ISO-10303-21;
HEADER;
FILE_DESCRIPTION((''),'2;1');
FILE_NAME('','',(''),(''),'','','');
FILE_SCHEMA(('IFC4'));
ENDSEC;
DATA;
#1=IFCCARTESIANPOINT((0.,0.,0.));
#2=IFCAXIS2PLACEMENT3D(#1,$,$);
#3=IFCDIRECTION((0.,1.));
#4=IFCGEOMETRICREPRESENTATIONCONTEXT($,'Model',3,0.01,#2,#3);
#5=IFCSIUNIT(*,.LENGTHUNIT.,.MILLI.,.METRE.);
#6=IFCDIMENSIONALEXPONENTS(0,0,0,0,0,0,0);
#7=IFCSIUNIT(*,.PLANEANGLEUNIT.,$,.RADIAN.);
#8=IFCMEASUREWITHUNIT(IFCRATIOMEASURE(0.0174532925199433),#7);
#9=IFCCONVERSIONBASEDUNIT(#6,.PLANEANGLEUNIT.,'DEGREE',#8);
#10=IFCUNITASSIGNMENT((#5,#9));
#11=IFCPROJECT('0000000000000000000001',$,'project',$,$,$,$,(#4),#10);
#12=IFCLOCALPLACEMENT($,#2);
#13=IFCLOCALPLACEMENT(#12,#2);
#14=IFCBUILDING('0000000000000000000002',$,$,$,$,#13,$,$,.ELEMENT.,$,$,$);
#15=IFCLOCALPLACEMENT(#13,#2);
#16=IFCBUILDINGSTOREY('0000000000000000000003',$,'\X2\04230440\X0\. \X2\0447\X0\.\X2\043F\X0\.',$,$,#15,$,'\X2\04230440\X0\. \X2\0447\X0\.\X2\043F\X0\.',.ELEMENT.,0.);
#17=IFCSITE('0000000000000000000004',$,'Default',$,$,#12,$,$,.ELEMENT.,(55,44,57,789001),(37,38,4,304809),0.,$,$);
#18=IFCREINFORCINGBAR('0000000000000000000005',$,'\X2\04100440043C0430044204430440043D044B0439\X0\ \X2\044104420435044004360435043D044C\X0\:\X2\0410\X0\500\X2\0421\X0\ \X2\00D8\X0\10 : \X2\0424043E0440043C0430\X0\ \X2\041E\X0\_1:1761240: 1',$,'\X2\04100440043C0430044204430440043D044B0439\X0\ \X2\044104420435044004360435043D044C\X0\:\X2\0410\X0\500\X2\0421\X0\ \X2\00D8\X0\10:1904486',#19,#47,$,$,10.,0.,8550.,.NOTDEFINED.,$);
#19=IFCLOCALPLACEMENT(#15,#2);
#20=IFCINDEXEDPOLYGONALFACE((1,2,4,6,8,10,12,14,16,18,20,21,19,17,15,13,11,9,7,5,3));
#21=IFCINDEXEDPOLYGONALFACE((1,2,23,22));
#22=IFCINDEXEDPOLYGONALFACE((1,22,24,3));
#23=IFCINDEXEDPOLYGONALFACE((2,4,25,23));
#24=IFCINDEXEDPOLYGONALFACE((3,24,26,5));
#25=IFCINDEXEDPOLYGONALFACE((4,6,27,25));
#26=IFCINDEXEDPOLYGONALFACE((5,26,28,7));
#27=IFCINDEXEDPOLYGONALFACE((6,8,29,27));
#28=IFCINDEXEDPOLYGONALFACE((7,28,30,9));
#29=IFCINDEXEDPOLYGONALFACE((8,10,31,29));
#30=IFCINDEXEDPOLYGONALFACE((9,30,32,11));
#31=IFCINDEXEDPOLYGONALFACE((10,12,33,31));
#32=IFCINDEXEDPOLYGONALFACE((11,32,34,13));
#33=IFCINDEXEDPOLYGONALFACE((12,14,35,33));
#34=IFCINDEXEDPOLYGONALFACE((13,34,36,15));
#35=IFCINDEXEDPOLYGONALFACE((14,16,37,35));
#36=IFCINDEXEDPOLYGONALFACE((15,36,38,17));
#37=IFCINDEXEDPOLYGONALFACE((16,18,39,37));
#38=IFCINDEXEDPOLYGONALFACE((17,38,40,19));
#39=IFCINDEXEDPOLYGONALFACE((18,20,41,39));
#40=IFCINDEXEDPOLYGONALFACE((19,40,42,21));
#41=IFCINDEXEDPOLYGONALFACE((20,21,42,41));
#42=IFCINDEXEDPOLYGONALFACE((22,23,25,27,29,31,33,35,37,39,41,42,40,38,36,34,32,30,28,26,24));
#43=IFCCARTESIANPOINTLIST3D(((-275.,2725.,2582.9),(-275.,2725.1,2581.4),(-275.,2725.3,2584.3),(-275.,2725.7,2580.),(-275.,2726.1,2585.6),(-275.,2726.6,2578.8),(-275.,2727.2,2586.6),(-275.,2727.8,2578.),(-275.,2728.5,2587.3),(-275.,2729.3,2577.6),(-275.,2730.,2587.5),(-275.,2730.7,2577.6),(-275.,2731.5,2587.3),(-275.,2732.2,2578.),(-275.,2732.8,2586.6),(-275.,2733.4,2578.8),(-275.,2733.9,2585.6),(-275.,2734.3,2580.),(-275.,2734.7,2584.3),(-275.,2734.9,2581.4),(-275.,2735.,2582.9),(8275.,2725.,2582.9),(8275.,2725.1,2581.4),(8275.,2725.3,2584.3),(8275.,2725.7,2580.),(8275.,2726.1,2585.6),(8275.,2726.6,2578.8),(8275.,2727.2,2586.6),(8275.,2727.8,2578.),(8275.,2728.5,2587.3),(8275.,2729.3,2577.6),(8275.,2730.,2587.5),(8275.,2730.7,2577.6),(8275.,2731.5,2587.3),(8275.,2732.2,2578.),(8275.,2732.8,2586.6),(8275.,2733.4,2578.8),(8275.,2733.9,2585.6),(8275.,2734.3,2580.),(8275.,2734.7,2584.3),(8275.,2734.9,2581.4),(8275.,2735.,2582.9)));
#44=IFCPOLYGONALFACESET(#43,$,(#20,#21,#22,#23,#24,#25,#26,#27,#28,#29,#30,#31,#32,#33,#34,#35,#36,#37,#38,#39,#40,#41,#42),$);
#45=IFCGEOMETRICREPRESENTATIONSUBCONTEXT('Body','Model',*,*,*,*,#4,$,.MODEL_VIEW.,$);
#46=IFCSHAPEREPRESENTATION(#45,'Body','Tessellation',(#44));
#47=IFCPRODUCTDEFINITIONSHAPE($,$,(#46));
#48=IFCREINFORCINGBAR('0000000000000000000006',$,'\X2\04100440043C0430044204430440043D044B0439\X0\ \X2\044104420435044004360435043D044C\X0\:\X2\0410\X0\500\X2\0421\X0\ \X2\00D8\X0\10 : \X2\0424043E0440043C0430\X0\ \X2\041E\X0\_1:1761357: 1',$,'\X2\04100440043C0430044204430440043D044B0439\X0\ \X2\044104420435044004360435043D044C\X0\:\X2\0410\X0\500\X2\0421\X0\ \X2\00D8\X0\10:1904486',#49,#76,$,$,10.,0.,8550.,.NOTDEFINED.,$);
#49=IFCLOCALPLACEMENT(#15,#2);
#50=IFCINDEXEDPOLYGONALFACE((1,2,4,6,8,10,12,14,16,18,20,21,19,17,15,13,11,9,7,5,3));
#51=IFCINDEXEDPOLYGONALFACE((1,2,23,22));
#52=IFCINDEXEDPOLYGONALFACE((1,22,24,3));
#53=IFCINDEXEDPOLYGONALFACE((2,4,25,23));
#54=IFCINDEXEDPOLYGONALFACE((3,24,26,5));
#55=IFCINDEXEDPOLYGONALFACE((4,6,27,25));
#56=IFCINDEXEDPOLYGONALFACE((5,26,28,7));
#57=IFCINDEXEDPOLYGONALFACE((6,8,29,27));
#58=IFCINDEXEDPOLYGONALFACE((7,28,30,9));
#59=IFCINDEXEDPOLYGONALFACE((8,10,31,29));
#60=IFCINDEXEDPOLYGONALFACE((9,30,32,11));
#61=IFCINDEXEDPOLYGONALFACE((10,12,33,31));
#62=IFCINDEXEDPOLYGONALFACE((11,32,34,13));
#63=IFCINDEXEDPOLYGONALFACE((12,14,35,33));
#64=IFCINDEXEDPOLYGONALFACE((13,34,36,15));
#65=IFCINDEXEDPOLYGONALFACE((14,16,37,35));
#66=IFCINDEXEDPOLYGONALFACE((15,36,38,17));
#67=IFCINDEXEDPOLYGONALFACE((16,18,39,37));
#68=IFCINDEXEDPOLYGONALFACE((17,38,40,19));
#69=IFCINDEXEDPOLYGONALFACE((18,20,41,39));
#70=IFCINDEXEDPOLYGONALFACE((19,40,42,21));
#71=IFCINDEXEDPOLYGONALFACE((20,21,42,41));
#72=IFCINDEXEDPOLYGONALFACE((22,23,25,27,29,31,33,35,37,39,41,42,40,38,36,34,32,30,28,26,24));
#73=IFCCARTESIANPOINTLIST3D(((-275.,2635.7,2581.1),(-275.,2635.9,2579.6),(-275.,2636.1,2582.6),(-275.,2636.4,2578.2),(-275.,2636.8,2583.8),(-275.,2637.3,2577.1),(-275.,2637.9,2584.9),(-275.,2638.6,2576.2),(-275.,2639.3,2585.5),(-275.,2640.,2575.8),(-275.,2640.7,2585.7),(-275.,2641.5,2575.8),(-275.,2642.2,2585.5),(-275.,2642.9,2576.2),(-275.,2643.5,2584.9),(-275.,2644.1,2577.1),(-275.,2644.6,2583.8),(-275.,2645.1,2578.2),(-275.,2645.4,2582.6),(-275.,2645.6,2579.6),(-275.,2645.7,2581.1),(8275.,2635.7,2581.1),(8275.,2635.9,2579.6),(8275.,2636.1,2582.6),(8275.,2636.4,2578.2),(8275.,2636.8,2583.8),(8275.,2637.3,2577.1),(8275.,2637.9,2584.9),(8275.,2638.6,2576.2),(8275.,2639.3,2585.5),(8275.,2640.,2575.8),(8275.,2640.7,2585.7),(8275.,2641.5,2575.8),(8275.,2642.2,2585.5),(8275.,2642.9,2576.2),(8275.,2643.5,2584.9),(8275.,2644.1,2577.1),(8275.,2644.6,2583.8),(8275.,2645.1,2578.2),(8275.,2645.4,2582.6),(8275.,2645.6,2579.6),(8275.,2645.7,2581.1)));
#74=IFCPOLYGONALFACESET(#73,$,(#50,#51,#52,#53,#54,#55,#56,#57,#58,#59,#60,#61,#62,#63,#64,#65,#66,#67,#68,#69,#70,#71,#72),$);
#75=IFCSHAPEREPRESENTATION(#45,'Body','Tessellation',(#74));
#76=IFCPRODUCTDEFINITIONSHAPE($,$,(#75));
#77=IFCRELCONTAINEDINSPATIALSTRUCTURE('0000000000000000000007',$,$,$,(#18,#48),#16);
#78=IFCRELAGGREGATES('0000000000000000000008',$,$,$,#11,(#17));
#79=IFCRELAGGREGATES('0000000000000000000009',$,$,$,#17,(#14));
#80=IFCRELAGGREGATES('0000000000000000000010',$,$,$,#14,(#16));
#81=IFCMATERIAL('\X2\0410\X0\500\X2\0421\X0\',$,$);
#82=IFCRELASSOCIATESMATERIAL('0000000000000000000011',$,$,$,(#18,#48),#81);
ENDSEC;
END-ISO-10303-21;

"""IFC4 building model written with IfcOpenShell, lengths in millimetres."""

from ifc_helpers import new_model, entity, si_unit, converted_unit, direction, origin, place, context, subcontext, project, spatial, material, element, save


model = new_model("IFC4")

# Units and contexts
model_context = context("Model", 3, precision=0.01, world=origin(), true_north=direction((0.0, 1.0)))
body_context = subcontext(model_context, "Body", "Model", "MODEL_VIEW")
ifc_project = project(units=[si_unit("LENGTHUNIT", "METRE", prefix="MILLI"), converted_unit("PLANEANGLEUNIT", "DEGREE", entity("IfcRatioMeasure", 0.0174532925199433), si_unit("PLANEANGLEUNIT", "RADIAN"), dimensions=[0, 0, 0, 0, 0, 0, 0])], contexts=[model_context])

# Site, building, storey
site_placement = place(None, origin())
site = spatial("IfcSite", under=ifc_project, at=site_placement, Name="Default", CompositionType="ELEMENT", RefLatitude=(55, 44, 57, 789001), RefLongitude=(37, 38, 4, 304809), RefElevation=0.0)
building_placement = place(site_placement, origin())
building = spatial("IfcBuilding", under=site, at=building_placement, CompositionType="ELEMENT")
storey_placement = place(building_placement, origin())
storey = spatial("IfcBuildingStorey", under=building, at=storey_placement, Name="Ур. ч.п.", LongName="Ур. ч.п.", CompositionType="ELEMENT", Elevation=0.0)

# Reinforcing bars
ifc_material_1 = material(Name="А500С")
reinforcing_bar_1_placement = place(storey_placement, origin())
element("IfcReinforcingBar", 1, at=reinforcing_bar_1_placement, inside=storey, material=ifc_material_1, Name="Арматурный стержень:А500С Ø10 : Форма О_1:1761240: 1", ObjectType="Арматурный стержень:А500С Ø10:1904486", BarLength=8550.0, CrossSectionArea=0.0, NominalDiameter=10.0, PredefinedType="NOTDEFINED", context=body_context, shape_type="AdvancedSweptSolid", body=[
    entity("IfcSweptDiskSolid", entity("IfcCompositeCurve", [entity("IfcCompositeCurveSegment", "CONTINUOUS", True, entity("IfcPolyline", [entity("IfcCartesianPoint", [-275.0, 2730.0, 2582.5]), entity("IfcCartesianPoint", [8275.0, 2730.0, 2582.5])]))], False), 5.0, None, 0.0, 1.0),
])
reinforcing_bar_2_placement = place(storey_placement, origin())
element("IfcReinforcingBar", 2, at=reinforcing_bar_2_placement, inside=storey, material=ifc_material_1, Name="Арматурный стержень:А500С Ø10 : Форма О_1:1761357: 1", ObjectType="Арматурный стержень:А500С Ø10:1904486", BarLength=8550.0, CrossSectionArea=0.0, NominalDiameter=10.0, PredefinedType="NOTDEFINED", context=body_context, shape_type="AdvancedSweptSolid", body=[
    entity("IfcSweptDiskSolid", entity("IfcCompositeCurve", [entity("IfcCompositeCurveSegment", "CONTINUOUS", True, entity("IfcPolyline", [entity("IfcCartesianPoint", [-275.0, 2640.7, 2580.7]), entity("IfcCartesianPoint", [8275.0, 2640.7, 2580.7])]))], False), 5.0, None, 0.0, 1.0),
])

save(model, "model.ifc")
